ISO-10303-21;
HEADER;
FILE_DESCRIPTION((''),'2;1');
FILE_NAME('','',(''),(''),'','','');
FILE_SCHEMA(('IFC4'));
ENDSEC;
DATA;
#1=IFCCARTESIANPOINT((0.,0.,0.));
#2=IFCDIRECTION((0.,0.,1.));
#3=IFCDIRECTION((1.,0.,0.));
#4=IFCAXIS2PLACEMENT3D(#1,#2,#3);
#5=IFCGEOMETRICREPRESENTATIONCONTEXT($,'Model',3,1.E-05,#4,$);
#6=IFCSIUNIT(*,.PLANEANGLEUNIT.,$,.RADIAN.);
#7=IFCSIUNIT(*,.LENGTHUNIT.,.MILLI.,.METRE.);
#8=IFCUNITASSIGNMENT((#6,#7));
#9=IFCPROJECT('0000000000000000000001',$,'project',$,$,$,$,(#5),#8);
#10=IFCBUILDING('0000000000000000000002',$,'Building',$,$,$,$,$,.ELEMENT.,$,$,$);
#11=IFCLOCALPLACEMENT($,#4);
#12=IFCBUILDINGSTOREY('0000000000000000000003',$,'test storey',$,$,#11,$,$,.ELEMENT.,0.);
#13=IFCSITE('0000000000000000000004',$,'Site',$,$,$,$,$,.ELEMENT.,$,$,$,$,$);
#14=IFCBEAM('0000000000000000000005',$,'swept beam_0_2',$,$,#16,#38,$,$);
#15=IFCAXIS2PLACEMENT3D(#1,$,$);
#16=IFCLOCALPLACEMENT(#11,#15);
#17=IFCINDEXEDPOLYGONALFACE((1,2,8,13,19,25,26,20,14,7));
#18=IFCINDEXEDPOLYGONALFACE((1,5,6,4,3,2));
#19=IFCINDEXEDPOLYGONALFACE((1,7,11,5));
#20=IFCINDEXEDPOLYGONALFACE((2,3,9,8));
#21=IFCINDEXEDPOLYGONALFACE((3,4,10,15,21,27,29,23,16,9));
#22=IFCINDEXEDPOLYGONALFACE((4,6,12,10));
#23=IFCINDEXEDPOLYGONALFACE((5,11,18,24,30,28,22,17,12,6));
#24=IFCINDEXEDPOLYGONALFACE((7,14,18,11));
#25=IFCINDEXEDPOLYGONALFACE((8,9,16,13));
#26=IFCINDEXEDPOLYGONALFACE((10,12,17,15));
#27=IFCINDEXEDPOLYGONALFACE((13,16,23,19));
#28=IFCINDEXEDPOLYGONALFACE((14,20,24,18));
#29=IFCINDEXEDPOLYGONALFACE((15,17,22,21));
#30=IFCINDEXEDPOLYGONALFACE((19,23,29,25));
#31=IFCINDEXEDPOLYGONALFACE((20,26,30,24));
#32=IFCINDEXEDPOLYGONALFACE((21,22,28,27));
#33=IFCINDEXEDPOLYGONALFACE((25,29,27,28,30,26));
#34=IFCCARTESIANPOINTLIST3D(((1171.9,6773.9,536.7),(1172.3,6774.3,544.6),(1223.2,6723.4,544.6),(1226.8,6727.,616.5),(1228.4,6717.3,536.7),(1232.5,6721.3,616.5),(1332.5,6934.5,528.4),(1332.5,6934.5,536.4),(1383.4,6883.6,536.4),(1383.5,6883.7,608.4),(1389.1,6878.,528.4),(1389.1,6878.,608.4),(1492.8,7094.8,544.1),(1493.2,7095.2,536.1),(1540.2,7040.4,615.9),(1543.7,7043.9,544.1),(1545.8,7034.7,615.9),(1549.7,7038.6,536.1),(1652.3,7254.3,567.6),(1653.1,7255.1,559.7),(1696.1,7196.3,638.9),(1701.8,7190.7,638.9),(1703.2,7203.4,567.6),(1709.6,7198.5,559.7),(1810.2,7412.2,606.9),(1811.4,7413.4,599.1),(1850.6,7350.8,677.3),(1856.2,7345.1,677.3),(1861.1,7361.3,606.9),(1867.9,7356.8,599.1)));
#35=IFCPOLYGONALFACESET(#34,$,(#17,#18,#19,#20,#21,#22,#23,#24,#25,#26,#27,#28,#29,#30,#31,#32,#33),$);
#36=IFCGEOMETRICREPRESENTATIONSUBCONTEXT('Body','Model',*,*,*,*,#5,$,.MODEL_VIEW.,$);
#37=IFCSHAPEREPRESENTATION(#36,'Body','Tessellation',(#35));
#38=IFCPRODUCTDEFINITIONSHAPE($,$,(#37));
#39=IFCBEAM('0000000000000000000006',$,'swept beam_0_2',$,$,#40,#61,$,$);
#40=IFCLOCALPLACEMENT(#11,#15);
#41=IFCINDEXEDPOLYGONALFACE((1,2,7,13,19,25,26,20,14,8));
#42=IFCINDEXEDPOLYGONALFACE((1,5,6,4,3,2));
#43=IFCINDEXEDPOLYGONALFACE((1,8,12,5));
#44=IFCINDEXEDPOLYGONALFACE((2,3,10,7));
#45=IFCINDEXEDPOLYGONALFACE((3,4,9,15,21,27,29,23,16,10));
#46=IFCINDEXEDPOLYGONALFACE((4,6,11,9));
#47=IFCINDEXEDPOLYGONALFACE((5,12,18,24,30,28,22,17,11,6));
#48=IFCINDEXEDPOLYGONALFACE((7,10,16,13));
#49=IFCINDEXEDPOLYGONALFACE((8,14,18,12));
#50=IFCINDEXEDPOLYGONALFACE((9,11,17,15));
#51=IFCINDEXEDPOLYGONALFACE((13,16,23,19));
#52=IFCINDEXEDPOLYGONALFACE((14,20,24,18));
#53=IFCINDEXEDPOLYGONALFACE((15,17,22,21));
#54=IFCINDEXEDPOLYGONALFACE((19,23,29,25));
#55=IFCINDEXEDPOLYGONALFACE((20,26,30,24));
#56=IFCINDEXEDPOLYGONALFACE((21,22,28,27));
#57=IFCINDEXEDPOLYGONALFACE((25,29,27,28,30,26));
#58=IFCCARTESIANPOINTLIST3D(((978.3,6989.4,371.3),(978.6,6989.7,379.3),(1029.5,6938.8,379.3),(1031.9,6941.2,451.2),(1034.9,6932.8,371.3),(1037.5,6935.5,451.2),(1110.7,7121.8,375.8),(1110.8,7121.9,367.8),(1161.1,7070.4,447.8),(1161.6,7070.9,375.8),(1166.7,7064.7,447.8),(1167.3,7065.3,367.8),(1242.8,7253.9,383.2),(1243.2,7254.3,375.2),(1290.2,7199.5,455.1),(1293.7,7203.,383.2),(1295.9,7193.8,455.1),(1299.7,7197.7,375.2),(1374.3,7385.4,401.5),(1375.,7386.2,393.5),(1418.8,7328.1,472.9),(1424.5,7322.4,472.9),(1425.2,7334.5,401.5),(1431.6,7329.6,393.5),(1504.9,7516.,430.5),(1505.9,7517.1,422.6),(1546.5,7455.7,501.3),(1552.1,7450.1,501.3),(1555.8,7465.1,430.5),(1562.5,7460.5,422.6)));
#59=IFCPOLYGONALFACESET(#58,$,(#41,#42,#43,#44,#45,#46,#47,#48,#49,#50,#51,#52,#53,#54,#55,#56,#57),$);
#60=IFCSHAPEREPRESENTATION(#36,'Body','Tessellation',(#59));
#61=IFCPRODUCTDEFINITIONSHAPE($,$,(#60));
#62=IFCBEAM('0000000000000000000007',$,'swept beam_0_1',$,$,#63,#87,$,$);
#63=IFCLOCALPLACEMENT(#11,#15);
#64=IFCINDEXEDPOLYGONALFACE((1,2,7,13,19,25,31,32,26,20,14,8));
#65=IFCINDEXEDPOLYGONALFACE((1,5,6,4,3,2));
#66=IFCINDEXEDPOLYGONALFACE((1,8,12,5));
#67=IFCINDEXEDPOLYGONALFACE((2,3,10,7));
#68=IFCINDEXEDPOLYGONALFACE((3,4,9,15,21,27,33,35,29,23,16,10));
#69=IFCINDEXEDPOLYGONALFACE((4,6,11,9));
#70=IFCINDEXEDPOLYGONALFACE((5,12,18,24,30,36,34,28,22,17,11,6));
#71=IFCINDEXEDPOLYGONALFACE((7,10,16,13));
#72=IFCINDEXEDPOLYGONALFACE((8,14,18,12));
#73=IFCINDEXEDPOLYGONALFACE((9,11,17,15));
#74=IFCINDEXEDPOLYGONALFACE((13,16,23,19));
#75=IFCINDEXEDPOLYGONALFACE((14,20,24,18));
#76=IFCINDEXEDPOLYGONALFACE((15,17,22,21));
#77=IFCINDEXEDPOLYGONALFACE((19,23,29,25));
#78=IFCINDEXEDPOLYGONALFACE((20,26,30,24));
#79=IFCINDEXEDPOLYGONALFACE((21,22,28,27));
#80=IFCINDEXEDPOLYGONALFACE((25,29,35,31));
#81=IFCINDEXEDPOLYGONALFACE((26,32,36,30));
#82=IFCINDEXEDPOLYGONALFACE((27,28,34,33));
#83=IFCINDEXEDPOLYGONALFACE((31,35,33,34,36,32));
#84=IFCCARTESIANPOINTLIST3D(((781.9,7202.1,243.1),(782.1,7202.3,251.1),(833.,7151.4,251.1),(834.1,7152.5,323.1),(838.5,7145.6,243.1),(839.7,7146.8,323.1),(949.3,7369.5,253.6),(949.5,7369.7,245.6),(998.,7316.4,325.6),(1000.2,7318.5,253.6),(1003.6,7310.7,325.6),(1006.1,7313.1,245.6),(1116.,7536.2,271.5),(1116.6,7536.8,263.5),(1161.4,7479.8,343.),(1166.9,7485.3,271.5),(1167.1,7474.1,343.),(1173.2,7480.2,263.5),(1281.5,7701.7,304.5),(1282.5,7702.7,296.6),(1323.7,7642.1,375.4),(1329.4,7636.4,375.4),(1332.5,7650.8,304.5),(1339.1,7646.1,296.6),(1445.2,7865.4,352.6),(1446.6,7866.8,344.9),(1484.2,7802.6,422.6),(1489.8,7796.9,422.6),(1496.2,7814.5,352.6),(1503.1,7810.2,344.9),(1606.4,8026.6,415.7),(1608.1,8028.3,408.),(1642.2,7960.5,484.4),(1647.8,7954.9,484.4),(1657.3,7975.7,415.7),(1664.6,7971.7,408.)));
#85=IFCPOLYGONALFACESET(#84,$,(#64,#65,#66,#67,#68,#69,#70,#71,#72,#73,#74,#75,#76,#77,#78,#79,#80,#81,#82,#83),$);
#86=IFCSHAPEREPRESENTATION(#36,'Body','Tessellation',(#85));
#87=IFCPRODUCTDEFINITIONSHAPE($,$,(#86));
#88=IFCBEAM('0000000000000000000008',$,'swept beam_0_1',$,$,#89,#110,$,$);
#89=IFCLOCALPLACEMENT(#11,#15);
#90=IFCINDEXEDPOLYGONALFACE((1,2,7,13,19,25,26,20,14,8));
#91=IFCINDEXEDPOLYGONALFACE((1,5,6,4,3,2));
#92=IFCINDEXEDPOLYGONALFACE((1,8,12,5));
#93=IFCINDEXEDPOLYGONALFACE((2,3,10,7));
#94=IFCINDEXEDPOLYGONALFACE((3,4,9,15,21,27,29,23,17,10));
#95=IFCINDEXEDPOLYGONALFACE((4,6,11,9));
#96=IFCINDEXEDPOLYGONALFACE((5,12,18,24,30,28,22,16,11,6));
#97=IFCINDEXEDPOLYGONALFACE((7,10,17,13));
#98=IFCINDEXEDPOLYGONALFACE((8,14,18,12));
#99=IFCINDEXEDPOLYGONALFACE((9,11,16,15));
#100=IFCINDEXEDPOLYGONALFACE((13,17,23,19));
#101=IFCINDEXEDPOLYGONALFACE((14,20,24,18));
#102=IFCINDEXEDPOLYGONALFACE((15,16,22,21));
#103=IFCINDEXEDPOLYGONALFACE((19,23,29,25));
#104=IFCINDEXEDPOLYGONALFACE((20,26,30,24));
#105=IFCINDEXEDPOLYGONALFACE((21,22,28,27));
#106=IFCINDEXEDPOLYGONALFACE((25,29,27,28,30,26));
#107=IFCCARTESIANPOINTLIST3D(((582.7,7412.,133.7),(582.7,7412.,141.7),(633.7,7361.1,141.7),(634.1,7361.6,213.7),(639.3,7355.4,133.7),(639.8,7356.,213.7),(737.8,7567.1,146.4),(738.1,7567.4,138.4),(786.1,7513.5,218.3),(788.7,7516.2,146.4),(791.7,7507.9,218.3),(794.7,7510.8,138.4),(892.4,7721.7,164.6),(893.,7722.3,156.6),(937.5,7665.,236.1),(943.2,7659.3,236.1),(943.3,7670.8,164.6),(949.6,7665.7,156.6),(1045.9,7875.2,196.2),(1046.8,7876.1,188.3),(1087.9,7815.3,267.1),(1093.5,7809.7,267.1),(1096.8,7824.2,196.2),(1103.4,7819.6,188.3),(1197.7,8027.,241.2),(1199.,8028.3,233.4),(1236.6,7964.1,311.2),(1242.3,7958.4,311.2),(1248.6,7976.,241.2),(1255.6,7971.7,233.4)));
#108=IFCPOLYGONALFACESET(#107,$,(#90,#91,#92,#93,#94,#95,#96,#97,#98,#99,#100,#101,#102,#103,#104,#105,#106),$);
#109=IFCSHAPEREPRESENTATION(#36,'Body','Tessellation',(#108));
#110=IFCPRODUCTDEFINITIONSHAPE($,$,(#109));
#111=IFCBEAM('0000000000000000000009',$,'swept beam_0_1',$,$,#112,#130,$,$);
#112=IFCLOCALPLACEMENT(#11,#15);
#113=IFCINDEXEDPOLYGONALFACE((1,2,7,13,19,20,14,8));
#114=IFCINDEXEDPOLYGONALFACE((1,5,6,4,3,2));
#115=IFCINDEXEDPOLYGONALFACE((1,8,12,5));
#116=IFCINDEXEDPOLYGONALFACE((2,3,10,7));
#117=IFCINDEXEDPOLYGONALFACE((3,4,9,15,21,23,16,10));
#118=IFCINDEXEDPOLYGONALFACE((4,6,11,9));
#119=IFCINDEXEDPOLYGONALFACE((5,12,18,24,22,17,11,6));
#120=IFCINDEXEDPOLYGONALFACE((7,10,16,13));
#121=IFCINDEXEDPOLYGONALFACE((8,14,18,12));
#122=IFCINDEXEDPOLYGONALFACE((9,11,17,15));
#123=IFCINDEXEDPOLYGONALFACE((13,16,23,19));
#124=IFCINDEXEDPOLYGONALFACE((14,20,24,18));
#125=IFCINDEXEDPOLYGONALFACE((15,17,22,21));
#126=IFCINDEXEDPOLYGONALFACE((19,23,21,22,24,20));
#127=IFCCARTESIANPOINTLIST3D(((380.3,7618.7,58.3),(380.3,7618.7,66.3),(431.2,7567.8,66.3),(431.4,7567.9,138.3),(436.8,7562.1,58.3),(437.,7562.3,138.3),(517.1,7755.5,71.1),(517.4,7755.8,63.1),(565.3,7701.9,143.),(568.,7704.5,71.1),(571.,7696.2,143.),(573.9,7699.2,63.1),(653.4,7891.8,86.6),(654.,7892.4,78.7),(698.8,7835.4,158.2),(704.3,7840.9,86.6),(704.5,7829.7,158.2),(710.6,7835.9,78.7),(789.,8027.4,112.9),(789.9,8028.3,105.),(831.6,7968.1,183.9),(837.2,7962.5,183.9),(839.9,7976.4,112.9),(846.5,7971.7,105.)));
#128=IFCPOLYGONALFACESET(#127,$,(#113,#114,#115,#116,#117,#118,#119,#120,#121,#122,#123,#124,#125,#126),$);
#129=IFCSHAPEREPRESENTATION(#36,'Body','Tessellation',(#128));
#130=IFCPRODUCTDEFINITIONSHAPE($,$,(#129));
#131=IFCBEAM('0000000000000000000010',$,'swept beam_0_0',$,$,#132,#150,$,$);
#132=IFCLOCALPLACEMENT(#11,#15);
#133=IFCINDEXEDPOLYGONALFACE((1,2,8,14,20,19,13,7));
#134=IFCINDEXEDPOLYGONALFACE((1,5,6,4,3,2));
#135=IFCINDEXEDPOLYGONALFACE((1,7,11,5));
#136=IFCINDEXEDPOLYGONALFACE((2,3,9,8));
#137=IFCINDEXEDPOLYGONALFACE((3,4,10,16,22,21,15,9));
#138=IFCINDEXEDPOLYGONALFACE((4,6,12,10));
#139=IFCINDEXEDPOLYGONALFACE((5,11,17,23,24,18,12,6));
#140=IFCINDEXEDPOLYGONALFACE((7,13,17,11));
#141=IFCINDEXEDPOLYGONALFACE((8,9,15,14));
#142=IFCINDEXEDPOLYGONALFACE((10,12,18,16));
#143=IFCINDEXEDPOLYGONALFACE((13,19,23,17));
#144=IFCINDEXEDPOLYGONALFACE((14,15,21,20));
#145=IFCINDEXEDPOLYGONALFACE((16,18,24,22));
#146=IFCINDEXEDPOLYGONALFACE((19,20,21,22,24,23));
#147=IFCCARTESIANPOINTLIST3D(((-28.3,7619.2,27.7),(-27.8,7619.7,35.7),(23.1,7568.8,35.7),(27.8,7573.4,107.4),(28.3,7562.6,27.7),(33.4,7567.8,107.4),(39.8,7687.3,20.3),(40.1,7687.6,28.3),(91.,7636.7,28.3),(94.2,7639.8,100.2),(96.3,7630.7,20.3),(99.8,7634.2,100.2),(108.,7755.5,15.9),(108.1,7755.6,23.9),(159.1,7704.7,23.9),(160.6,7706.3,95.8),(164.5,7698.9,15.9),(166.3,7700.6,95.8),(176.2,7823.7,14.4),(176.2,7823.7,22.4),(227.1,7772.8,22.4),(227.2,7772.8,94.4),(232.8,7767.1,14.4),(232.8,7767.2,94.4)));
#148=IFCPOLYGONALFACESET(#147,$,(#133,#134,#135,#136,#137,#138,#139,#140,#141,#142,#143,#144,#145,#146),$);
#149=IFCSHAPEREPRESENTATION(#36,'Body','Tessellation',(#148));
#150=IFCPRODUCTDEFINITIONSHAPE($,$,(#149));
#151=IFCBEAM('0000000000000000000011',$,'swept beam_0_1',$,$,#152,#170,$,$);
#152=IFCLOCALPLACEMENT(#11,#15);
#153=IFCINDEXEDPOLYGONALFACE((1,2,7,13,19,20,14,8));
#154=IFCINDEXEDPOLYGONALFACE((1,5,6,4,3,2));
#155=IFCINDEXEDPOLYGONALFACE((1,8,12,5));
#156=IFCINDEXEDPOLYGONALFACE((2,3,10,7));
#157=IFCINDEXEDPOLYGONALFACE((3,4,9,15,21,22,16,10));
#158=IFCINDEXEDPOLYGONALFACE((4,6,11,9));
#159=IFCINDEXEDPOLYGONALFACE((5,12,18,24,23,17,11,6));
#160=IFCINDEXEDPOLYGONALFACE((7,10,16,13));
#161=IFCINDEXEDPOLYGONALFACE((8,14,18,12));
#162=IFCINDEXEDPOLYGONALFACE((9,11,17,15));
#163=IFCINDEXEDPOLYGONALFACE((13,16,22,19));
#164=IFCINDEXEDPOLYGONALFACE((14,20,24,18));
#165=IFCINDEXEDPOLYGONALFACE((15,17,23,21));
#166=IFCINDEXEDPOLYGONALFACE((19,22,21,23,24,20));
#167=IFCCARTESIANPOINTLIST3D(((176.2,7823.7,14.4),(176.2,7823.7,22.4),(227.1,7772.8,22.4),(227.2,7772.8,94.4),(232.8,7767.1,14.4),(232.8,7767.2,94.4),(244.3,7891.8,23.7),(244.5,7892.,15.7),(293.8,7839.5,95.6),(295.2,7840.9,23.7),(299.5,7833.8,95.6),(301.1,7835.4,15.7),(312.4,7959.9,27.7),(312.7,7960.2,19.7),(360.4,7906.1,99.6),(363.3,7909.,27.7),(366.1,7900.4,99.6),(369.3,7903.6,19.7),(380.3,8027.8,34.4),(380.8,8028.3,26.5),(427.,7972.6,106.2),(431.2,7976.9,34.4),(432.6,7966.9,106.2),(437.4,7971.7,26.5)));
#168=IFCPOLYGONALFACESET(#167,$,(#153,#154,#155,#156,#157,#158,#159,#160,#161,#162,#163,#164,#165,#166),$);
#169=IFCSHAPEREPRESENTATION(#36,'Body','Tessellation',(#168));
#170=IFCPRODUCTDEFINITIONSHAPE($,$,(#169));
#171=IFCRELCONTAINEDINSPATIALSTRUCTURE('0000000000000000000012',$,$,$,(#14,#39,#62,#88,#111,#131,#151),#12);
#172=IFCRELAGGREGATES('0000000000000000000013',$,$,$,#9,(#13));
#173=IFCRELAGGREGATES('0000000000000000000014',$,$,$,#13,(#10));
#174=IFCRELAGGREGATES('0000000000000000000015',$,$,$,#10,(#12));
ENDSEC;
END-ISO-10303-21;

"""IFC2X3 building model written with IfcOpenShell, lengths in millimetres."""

from ifc_helpers import new_model, entity, si_unit, origin_with_axes, place, context, subcontext, project, spatial, element, save


model = new_model("IFC2X3")

# Units and contexts
model_context = context("Model", 3, precision=1e-05, world=origin_with_axes())
body_context = subcontext(model_context, "Body", "Model", "MODEL_VIEW")
ifc_project = project(units=[si_unit("PLANEANGLEUNIT", "RADIAN"), si_unit("LENGTHUNIT", "METRE", prefix="MILLI")], contexts=[model_context])

# Site, building, storey
site = spatial("IfcSite", under=ifc_project, Name="Site", CompositionType="ELEMENT")
building = spatial("IfcBuilding", under=site, Name="Building", CompositionType="ELEMENT")
storey_placement = place(None, origin_with_axes())
storey = spatial("IfcBuildingStorey", under=building, at=storey_placement, Name="test storey", CompositionType="ELEMENT", Elevation=0.0)

# Beams
beam_1_placement = place(storey_placement, origin_with_axes())
element("IfcBeam", 1, at=beam_1_placement, inside=storey, Name="swept beam_0_2", context=body_context, shape_type="SweptSolid", body=[
    entity("IfcRevolvedAreaSolid", entity("IfcArbitraryClosedProfileDef", "AREA", None, entity("IfcPolyline", [entity("IfcCartesianPoint", [-80.0, 40.0]), entity("IfcCartesianPoint", [-80.0, 32.0]), entity("IfcCartesianPoint", [-8.0, 32.0]), entity("IfcCartesianPoint", [-8.0, -40.0]), entity("IfcCartesianPoint", [0.0, -40.0]), entity("IfcCartesianPoint", [0.0, 40.0]), entity("IfcCartesianPoint", [-80.0, 40.0])])), entity("IfcAxis2Placement3D", entity("IfcCartesianPoint", [1200.1, 6745.6, 536.7]), entity("IfcDirection", [-0.7053, -0.7053, 0.0712]), entity("IfcDirection", [-0.0503, -0.0503, -0.9975])), entity("IfcAxis1Placement", entity("IfcCartesianPoint", [-3245.2, 0.0, 0.0]), entity("IfcDirection", [0.0, 1.0, 0.0])), 0.280272),
])
beam_2_placement = place(storey_placement, origin_with_axes())
element("IfcBeam", 2, at=beam_2_placement, inside=storey, Name="swept beam_0_2", context=body_context, shape_type="SweptSolid", body=[
    entity("IfcRevolvedAreaSolid", entity("IfcArbitraryClosedProfileDef", "AREA", None, entity("IfcPolyline", [entity("IfcCartesianPoint", [-80.0, 40.0]), entity("IfcCartesianPoint", [-80.0, 32.0]), entity("IfcCartesianPoint", [-8.0, 32.0]), entity("IfcCartesianPoint", [-8.0, -40.0]), entity("IfcCartesianPoint", [0.0, -40.0]), entity("IfcCartesianPoint", [0.0, 40.0]), entity("IfcCartesianPoint", [-80.0, 40.0])])), entity("IfcAxis2Placement3D", entity("IfcCartesianPoint", [1006.6, 6961.1, 371.3]), entity("IfcDirection", [-0.7063, -0.7063, 0.0476]), entity("IfcDirection", [-0.0337, -0.0337, -0.9989])), entity("IfcAxis1Placement", entity("IfcCartesianPoint", [-3222.7, 0.0, 0.0]), entity("IfcDirection", [0.0, 1.0, 0.0])), 0.232623),
])
beam_3_placement = place(storey_placement, origin_with_axes())
element("IfcBeam", 3, at=beam_3_placement, inside=storey, Name="swept beam_0_1", context=body_context, shape_type="SweptSolid", body=[
    entity("IfcRevolvedAreaSolid", entity("IfcArbitraryClosedProfileDef", "AREA", None, entity("IfcPolyline", [entity("IfcCartesianPoint", [-80.0, 40.0]), entity("IfcCartesianPoint", [-80.0, 32.0]), entity("IfcCartesianPoint", [-8.0, 32.0]), entity("IfcCartesianPoint", [-8.0, -40.0]), entity("IfcCartesianPoint", [0.0, -40.0]), entity("IfcCartesianPoint", [0.0, 40.0]), entity("IfcCartesianPoint", [-80.0, 40.0])])), entity("IfcAxis2Placement3D", entity("IfcCartesianPoint", [810.2, 7173.9, 243.1]), entity("IfcDirection", [-0.7069, -0.7069, 0.0216]), entity("IfcDirection", [-0.0153, -0.0153, -0.9998])), entity("IfcAxis1Placement", entity("IfcCartesianPoint", [-3661.1, 0.0, 0.0]), entity("IfcDirection", [0.0, 1.0, 0.0])), 0.323701),
])
beam_4_placement = place(storey_placement, origin_with_axes())
element("IfcBeam", 4, at=beam_4_placement, inside=storey, Name="swept beam_0_1", context=body_context, shape_type="SweptSolid", body=[
    entity("IfcRevolvedAreaSolid", entity("IfcArbitraryClosedProfileDef", "AREA", None, entity("IfcPolyline", [entity("IfcCartesianPoint", [-80.0, 40.0]), entity("IfcCartesianPoint", [-80.0, 32.0]), entity("IfcCartesianPoint", [-8.0, 32.0]), entity("IfcCartesianPoint", [-8.0, -40.0]), entity("IfcCartesianPoint", [0.0, -40.0]), entity("IfcCartesianPoint", [0.0, 40.0]), entity("IfcCartesianPoint", [-80.0, 40.0])])), entity("IfcAxis2Placement3D", entity("IfcCartesianPoint", [611.0, 7383.7, 133.7]), entity("IfcDirection", [-0.7071, -0.7071, 0.0096]), entity("IfcDirection", [-0.0068, -0.0068, -1.0])), entity("IfcAxis1Placement", entity("IfcCartesianPoint", [-3560.6, 0.0, 0.0]), entity("IfcDirection", [0.0, 1.0, 0.0])), 0.247006),
])
beam_5_placement = place(storey_placement, origin_with_axes())
element("IfcBeam", 5, at=beam_5_placement, inside=storey, Name="swept beam_0_1", context=body_context, shape_type="SweptSolid", body=[
    entity("IfcRevolvedAreaSolid", entity("IfcArbitraryClosedProfileDef", "AREA", None, entity("IfcPolyline", [entity("IfcCartesianPoint", [-80.0, 40.0]), entity("IfcCartesianPoint", [-80.0, 32.0]), entity("IfcCartesianPoint", [-8.0, 32.0]), entity("IfcCartesianPoint", [-8.0, -40.0]), entity("IfcCartesianPoint", [0.0, -40.0]), entity("IfcCartesianPoint", [0.0, 40.0]), entity("IfcCartesianPoint", [-80.0, 40.0])])), entity("IfcAxis2Placement3D", entity("IfcCartesianPoint", [408.6, 7590.4, 58.3]), entity("IfcDirection", [-0.7071, -0.7071, 0.0034]), entity("IfcDirection", [-0.0024, -0.0024, -1.0])), entity("IfcAxis1Placement", entity("IfcCartesianPoint", [-3471.9, 0.0, 0.0]), entity("IfcDirection", [0.0, 1.0, 0.0])), 0.167586),
])
beam_6_placement = place(storey_placement, origin_with_axes())
element("IfcBeam", 6, at=beam_6_placement, inside=storey, Name="swept beam_0_0", context=body_context, shape_type="SweptSolid", body=[
    entity("IfcRevolvedAreaSolid", entity("IfcArbitraryClosedProfileDef", "AREA", None, entity("IfcPolyline", [entity("IfcCartesianPoint", [-80.0, 40.0]), entity("IfcCartesianPoint", [-80.0, 32.0]), entity("IfcCartesianPoint", [-8.0, 32.0]), entity("IfcCartesianPoint", [-8.0, -40.0]), entity("IfcCartesianPoint", [0.0, -40.0]), entity("IfcCartesianPoint", [0.0, 40.0]), entity("IfcCartesianPoint", [-80.0, 40.0])])), entity("IfcAxis2Placement3D", entity("IfcCartesianPoint", [0.0, 7590.9, 27.7]), entity("IfcDirection", [-0.7042, -0.7042, 0.0913]), entity("IfcDirection", [-0.0645, -0.0645, -0.9958])), entity("IfcAxis1Placement", entity("IfcCartesianPoint", [-3195.0, 0.0, 0.0]), entity("IfcDirection", [0.0, 1.0, 0.0])), 0.090651),
])
beam_7_placement = place(storey_placement, origin_with_axes())
element("IfcBeam", 7, at=beam_7_placement, inside=storey, Name="swept beam_0_1", context=body_context, shape_type="SweptSolid", body=[
    entity("IfcRevolvedAreaSolid", entity("IfcArbitraryClosedProfileDef", "AREA", None, entity("IfcPolyline", [entity("IfcCartesianPoint", [-80.0, 40.0]), entity("IfcCartesianPoint", [-80.0, 32.0]), entity("IfcCartesianPoint", [-8.0, 32.0]), entity("IfcCartesianPoint", [-8.0, -40.0]), entity("IfcCartesianPoint", [0.0, -40.0]), entity("IfcCartesianPoint", [0.0, 40.0]), entity("IfcCartesianPoint", [-80.0, 40.0])])), entity("IfcAxis2Placement3D", entity("IfcCartesianPoint", [204.5, 7795.4, 14.4]), entity("IfcDirection", [-0.7071, -0.7071, 0.0007]), entity("IfcDirection", [-0.0005, -0.0005, -1.0])), entity("IfcAxis1Placement", entity("IfcCartesianPoint", [-3405.4, 0.0, 0.0]), entity("IfcDirection", [0.0, 1.0, 0.0])), 0.085059),
])

save(model, "model.ifc")
